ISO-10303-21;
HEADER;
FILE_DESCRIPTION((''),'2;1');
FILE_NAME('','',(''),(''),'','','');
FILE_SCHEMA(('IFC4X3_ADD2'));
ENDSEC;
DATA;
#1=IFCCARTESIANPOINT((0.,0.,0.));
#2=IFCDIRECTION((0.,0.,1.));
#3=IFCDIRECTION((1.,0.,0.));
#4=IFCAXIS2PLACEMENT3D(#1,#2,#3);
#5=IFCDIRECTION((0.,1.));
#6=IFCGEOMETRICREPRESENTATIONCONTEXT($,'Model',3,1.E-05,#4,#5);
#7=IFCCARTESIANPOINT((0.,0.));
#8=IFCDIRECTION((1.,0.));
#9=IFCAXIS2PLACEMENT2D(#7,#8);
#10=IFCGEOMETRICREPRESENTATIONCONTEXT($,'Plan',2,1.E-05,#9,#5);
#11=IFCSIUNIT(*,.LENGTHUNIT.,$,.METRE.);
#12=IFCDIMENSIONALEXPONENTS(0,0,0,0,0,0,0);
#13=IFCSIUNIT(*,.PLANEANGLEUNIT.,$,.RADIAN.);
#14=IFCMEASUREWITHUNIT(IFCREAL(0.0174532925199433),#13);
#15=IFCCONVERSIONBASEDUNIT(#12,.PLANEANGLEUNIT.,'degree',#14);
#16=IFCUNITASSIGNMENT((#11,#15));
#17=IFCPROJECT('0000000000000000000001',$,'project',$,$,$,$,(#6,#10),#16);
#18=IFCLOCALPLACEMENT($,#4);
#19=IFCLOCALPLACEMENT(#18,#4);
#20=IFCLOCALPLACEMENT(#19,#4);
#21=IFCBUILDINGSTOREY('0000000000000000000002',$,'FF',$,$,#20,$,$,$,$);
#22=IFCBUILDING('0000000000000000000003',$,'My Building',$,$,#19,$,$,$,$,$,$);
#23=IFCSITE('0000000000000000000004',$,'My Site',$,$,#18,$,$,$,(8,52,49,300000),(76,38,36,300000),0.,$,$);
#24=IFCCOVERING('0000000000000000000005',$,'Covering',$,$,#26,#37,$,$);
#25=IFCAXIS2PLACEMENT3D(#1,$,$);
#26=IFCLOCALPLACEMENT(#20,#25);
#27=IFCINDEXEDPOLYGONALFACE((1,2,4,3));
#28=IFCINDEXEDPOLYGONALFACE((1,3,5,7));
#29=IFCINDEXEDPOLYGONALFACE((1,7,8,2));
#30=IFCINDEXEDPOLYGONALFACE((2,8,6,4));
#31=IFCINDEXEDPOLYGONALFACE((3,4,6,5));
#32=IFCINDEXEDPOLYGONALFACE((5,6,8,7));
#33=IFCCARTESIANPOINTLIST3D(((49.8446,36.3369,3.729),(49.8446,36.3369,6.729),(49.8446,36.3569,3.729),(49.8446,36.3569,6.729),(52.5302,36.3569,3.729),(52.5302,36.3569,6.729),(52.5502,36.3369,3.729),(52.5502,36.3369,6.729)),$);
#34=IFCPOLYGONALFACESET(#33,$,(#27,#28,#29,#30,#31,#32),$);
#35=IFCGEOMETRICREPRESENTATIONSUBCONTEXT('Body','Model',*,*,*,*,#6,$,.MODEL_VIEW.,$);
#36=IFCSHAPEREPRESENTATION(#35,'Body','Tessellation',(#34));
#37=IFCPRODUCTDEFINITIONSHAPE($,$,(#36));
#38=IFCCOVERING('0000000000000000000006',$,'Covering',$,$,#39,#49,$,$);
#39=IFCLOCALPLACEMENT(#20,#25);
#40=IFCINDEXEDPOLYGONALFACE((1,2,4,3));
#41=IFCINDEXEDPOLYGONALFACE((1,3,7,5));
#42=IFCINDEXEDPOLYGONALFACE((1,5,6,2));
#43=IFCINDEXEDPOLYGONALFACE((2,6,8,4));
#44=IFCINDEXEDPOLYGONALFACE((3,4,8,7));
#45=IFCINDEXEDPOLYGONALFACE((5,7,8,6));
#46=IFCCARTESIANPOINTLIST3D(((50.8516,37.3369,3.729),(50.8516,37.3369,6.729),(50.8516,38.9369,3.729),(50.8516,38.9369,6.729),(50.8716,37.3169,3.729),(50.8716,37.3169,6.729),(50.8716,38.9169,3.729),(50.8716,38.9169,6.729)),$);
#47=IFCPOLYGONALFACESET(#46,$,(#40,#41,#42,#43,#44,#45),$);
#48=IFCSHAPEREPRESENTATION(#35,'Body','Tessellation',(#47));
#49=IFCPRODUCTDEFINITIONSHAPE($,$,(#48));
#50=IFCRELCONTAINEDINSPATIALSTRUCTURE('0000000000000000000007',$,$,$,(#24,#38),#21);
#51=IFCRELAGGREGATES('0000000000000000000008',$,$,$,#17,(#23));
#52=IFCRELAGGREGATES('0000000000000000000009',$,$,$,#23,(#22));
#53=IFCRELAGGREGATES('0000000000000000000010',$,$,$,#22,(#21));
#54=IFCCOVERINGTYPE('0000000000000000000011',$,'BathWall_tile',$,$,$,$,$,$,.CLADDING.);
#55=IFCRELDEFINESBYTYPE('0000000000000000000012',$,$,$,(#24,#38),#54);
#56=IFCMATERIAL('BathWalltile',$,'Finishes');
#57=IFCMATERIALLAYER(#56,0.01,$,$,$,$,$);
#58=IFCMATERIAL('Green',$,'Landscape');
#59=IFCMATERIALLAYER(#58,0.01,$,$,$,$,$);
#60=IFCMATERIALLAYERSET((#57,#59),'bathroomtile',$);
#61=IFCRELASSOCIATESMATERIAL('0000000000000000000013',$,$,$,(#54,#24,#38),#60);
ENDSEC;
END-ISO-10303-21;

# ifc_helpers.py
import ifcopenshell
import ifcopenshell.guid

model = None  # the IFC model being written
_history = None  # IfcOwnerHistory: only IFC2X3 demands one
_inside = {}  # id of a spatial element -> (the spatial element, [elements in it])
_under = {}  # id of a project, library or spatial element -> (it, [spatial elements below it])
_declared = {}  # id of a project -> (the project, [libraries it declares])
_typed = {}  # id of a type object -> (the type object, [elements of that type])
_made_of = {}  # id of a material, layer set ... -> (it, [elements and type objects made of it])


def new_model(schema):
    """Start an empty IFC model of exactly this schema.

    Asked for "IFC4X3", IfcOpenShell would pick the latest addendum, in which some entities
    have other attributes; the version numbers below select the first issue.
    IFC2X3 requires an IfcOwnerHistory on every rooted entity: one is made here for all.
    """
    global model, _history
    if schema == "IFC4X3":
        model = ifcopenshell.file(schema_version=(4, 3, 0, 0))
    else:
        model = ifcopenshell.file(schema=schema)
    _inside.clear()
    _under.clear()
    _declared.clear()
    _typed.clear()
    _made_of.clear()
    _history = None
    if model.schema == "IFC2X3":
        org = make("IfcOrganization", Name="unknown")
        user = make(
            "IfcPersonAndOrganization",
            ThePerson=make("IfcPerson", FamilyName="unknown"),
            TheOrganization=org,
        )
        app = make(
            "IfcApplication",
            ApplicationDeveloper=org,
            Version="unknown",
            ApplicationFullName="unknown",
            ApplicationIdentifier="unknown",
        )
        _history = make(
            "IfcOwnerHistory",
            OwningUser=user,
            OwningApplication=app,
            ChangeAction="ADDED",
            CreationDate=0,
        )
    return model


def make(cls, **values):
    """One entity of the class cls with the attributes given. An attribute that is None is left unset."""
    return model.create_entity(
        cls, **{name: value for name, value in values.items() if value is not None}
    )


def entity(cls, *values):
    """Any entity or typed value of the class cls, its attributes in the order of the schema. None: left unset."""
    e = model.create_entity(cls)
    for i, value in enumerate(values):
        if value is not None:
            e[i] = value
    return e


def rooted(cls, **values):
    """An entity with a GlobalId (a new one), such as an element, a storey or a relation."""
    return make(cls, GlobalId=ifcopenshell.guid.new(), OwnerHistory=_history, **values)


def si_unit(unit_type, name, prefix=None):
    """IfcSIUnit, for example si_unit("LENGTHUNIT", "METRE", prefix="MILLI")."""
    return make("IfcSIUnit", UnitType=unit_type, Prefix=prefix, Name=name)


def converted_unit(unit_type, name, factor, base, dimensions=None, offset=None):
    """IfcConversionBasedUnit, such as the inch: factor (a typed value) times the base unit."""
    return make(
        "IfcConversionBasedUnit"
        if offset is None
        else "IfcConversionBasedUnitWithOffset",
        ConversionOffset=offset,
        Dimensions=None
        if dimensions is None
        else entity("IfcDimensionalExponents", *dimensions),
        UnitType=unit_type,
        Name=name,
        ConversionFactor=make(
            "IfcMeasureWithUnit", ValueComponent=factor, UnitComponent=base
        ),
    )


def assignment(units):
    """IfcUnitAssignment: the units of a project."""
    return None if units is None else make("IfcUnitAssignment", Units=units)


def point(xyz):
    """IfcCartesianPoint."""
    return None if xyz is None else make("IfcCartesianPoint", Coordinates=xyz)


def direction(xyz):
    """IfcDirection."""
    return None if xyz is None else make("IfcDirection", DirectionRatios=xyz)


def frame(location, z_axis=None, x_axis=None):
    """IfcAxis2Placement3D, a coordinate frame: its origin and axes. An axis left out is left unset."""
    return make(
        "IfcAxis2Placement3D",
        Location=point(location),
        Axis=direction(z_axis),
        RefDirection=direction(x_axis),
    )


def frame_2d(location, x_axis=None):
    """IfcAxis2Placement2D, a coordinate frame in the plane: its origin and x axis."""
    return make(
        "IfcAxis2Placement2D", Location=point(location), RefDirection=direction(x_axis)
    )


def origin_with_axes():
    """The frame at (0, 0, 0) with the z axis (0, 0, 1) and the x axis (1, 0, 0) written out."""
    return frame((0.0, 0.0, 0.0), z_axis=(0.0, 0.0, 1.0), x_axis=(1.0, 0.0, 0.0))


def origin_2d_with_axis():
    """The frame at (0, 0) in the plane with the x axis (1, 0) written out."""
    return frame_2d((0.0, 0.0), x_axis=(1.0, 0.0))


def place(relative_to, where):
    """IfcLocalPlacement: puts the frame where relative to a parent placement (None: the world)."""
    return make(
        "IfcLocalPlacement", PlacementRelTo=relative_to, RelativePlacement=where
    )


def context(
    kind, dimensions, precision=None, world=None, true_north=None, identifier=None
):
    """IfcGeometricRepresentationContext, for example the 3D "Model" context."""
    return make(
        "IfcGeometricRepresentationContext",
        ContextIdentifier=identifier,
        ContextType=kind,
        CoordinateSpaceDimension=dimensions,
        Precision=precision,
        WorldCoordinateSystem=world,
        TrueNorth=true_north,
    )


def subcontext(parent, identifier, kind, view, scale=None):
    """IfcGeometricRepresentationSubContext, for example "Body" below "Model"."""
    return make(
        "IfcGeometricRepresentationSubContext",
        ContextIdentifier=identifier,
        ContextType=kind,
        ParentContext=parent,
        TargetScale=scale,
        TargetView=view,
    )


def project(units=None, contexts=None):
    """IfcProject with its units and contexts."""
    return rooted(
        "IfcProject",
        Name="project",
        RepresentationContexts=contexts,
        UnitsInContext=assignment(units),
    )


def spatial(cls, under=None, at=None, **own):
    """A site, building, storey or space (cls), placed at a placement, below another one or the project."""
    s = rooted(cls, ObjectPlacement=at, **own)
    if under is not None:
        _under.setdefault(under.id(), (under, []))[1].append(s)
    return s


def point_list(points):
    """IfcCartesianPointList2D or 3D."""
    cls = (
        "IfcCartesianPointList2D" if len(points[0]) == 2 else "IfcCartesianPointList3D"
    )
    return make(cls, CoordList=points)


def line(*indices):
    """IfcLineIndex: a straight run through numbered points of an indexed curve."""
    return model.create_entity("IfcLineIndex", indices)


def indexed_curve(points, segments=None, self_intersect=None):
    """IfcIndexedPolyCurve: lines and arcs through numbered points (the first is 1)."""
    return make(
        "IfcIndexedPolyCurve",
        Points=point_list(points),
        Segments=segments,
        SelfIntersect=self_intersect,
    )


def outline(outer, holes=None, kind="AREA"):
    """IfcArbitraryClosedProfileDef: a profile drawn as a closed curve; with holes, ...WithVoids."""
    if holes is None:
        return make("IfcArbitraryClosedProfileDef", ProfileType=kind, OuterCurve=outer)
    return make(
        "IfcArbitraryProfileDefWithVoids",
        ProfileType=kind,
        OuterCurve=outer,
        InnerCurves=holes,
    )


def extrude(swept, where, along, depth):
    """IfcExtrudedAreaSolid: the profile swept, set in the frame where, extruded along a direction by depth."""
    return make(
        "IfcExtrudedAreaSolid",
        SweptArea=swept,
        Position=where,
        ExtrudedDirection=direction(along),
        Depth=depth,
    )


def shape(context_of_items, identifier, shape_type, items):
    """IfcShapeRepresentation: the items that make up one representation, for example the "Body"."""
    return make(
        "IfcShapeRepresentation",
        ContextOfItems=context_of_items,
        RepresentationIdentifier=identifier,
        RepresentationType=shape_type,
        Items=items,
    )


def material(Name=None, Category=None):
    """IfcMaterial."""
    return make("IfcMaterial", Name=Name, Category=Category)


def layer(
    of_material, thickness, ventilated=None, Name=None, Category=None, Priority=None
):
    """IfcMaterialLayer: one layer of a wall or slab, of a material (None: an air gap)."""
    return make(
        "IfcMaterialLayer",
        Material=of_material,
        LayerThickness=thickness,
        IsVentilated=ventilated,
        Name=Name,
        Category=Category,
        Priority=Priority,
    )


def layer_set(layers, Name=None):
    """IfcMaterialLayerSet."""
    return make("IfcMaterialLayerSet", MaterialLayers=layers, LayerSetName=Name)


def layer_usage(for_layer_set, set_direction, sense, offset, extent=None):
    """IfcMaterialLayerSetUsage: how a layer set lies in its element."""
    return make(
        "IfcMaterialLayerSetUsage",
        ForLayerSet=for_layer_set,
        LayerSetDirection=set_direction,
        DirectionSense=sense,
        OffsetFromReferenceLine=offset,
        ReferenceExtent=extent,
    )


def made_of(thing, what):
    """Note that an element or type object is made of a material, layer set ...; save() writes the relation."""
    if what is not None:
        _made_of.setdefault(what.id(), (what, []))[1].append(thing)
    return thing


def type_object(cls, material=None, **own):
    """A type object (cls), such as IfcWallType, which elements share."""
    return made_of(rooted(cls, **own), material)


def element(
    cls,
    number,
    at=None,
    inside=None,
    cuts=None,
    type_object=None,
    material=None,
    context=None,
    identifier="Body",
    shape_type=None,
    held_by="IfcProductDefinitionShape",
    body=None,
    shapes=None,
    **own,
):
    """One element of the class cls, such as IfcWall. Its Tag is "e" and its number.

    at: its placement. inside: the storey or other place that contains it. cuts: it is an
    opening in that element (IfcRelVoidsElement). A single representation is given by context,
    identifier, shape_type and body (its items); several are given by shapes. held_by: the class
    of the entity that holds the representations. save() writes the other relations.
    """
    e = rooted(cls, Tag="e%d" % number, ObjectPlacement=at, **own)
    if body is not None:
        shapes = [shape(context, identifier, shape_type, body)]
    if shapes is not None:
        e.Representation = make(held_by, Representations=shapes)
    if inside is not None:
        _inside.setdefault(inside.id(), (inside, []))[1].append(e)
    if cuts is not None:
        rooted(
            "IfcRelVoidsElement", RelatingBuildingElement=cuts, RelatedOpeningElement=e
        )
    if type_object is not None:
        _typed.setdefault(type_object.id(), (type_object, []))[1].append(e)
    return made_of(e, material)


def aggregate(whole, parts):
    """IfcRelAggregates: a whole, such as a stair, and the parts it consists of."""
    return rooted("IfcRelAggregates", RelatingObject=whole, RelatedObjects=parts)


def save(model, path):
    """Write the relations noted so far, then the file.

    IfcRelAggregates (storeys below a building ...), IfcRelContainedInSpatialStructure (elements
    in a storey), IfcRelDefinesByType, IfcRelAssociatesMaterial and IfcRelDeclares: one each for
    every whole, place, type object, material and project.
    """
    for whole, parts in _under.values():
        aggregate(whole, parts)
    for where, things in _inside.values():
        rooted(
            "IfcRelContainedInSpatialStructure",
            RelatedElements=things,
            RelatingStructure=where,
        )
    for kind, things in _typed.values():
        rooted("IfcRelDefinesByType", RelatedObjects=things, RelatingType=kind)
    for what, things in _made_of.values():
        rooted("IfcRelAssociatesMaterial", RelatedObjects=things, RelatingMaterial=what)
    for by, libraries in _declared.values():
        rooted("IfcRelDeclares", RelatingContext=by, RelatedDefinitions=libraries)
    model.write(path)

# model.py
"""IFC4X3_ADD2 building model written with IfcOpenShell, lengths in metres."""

from ifc_helpers import new_model, entity, si_unit, converted_unit, direction, frame, origin_with_axes, origin_2d_with_axis, place, context, subcontext, project, spatial, line, indexed_curve, outline, extrude, material, layer, layer_set, layer_usage, type_object, element, save


model = new_model("IFC4X3_ADD2")

# Units and contexts
model_context = context("Model", 3, precision=1e-05, world=origin_with_axes(), true_north=direction((0.0, 1.0)))
plan_context = context("Plan", 2, precision=1e-05, world=origin_2d_with_axis(), true_north=direction((0.0, 1.0)))
body_context_1 = subcontext(model_context, "Body", "Model", "MODEL_VIEW")
ifc_project = project(units=[si_unit("LENGTHUNIT", "METRE"), converted_unit("PLANEANGLEUNIT", "degree", entity("IfcReal", 0.0174532925199433), si_unit("PLANEANGLEUNIT", "RADIAN"), dimensions=[0, 0, 0, 0, 0, 0, 0])], contexts=[model_context, plan_context])

# Site, building, storey
site_placement = place(None, origin_with_axes())
site = spatial("IfcSite", under=ifc_project, at=site_placement, Name="My Site", RefLatitude=(8, 52, 49, 300000), RefLongitude=(76, 38, 36, 300000), RefElevation=0.0)
building_placement = place(site_placement, origin_with_axes())
building = spatial("IfcBuilding", under=site, at=building_placement, Name="My Building")
storey_placement = place(building_placement, origin_with_axes())
storey = spatial("IfcBuildingStorey", under=building, at=storey_placement, Name="FF")

# Coverings
ifc_material_1 = material(Name="BathWalltile", Category="Finishes")
ifc_layer_1 = layer(ifc_material_1, 0.01)
ifc_material_2 = material(Name="Green", Category="Landscape")
ifc_layer_2 = layer(ifc_material_2, 0.01)
ifc_layer_set_1 = layer_set([ifc_layer_1, ifc_layer_2], Name="bathroomtile")
covering_type = type_object("IfcCoveringType", Name="BathWall_tile", PredefinedType="CLADDING", material=ifc_layer_set_1)
ifc_layer_usage_1 = layer_usage(ifc_layer_set_1, "AXIS2", "NEGATIVE", 0.0)
covering_1_placement = place(storey_placement, frame((49.8446, 36.3569, 3.729), z_axis=(0.0, 0.0, 1.0), x_axis=(1.0, 0.0, 0.0)))
element("IfcCovering", 1, at=covering_1_placement, inside=storey, type_object=covering_type, material=ifc_layer_usage_1, Name="Covering", context=body_context_1, shape_type="SweptSolid", body=[
    extrude(outline(indexed_curve([(0.0, -0.02), (0.0, 0.0), (2.6856, 0.0), (2.7056, -0.02)], segments=[line(1, 2, 3, 4, 1)])), origin_with_axes(), (0.0, 0.0, 1.0), 3.0),
])
ifc_layer_usage_2 = layer_usage(ifc_layer_set_1, "AXIS2", "POSITIVE", 0.0)
covering_2_placement = place(storey_placement, frame((50.8716, 37.3169, 3.729), z_axis=(0.0, 0.0, 1.0), x_axis=(0.0, 1.0, 0.0)))
element("IfcCovering", 2, at=covering_2_placement, inside=storey, type_object=covering_type, material=ifc_layer_usage_2, Name="Covering", context=body_context_1, shape_type="SweptSolid", body=[
    extrude(outline(indexed_curve([(0.0, 0.0), (0.02, 0.02), (1.62, 0.02), (1.6, 0.0)], segments=[line(1, 2, 3, 4, 1)])), origin_with_axes(), (0.0, 0.0, 1.0), 3.0),
])

save(model, "model.ifc")
